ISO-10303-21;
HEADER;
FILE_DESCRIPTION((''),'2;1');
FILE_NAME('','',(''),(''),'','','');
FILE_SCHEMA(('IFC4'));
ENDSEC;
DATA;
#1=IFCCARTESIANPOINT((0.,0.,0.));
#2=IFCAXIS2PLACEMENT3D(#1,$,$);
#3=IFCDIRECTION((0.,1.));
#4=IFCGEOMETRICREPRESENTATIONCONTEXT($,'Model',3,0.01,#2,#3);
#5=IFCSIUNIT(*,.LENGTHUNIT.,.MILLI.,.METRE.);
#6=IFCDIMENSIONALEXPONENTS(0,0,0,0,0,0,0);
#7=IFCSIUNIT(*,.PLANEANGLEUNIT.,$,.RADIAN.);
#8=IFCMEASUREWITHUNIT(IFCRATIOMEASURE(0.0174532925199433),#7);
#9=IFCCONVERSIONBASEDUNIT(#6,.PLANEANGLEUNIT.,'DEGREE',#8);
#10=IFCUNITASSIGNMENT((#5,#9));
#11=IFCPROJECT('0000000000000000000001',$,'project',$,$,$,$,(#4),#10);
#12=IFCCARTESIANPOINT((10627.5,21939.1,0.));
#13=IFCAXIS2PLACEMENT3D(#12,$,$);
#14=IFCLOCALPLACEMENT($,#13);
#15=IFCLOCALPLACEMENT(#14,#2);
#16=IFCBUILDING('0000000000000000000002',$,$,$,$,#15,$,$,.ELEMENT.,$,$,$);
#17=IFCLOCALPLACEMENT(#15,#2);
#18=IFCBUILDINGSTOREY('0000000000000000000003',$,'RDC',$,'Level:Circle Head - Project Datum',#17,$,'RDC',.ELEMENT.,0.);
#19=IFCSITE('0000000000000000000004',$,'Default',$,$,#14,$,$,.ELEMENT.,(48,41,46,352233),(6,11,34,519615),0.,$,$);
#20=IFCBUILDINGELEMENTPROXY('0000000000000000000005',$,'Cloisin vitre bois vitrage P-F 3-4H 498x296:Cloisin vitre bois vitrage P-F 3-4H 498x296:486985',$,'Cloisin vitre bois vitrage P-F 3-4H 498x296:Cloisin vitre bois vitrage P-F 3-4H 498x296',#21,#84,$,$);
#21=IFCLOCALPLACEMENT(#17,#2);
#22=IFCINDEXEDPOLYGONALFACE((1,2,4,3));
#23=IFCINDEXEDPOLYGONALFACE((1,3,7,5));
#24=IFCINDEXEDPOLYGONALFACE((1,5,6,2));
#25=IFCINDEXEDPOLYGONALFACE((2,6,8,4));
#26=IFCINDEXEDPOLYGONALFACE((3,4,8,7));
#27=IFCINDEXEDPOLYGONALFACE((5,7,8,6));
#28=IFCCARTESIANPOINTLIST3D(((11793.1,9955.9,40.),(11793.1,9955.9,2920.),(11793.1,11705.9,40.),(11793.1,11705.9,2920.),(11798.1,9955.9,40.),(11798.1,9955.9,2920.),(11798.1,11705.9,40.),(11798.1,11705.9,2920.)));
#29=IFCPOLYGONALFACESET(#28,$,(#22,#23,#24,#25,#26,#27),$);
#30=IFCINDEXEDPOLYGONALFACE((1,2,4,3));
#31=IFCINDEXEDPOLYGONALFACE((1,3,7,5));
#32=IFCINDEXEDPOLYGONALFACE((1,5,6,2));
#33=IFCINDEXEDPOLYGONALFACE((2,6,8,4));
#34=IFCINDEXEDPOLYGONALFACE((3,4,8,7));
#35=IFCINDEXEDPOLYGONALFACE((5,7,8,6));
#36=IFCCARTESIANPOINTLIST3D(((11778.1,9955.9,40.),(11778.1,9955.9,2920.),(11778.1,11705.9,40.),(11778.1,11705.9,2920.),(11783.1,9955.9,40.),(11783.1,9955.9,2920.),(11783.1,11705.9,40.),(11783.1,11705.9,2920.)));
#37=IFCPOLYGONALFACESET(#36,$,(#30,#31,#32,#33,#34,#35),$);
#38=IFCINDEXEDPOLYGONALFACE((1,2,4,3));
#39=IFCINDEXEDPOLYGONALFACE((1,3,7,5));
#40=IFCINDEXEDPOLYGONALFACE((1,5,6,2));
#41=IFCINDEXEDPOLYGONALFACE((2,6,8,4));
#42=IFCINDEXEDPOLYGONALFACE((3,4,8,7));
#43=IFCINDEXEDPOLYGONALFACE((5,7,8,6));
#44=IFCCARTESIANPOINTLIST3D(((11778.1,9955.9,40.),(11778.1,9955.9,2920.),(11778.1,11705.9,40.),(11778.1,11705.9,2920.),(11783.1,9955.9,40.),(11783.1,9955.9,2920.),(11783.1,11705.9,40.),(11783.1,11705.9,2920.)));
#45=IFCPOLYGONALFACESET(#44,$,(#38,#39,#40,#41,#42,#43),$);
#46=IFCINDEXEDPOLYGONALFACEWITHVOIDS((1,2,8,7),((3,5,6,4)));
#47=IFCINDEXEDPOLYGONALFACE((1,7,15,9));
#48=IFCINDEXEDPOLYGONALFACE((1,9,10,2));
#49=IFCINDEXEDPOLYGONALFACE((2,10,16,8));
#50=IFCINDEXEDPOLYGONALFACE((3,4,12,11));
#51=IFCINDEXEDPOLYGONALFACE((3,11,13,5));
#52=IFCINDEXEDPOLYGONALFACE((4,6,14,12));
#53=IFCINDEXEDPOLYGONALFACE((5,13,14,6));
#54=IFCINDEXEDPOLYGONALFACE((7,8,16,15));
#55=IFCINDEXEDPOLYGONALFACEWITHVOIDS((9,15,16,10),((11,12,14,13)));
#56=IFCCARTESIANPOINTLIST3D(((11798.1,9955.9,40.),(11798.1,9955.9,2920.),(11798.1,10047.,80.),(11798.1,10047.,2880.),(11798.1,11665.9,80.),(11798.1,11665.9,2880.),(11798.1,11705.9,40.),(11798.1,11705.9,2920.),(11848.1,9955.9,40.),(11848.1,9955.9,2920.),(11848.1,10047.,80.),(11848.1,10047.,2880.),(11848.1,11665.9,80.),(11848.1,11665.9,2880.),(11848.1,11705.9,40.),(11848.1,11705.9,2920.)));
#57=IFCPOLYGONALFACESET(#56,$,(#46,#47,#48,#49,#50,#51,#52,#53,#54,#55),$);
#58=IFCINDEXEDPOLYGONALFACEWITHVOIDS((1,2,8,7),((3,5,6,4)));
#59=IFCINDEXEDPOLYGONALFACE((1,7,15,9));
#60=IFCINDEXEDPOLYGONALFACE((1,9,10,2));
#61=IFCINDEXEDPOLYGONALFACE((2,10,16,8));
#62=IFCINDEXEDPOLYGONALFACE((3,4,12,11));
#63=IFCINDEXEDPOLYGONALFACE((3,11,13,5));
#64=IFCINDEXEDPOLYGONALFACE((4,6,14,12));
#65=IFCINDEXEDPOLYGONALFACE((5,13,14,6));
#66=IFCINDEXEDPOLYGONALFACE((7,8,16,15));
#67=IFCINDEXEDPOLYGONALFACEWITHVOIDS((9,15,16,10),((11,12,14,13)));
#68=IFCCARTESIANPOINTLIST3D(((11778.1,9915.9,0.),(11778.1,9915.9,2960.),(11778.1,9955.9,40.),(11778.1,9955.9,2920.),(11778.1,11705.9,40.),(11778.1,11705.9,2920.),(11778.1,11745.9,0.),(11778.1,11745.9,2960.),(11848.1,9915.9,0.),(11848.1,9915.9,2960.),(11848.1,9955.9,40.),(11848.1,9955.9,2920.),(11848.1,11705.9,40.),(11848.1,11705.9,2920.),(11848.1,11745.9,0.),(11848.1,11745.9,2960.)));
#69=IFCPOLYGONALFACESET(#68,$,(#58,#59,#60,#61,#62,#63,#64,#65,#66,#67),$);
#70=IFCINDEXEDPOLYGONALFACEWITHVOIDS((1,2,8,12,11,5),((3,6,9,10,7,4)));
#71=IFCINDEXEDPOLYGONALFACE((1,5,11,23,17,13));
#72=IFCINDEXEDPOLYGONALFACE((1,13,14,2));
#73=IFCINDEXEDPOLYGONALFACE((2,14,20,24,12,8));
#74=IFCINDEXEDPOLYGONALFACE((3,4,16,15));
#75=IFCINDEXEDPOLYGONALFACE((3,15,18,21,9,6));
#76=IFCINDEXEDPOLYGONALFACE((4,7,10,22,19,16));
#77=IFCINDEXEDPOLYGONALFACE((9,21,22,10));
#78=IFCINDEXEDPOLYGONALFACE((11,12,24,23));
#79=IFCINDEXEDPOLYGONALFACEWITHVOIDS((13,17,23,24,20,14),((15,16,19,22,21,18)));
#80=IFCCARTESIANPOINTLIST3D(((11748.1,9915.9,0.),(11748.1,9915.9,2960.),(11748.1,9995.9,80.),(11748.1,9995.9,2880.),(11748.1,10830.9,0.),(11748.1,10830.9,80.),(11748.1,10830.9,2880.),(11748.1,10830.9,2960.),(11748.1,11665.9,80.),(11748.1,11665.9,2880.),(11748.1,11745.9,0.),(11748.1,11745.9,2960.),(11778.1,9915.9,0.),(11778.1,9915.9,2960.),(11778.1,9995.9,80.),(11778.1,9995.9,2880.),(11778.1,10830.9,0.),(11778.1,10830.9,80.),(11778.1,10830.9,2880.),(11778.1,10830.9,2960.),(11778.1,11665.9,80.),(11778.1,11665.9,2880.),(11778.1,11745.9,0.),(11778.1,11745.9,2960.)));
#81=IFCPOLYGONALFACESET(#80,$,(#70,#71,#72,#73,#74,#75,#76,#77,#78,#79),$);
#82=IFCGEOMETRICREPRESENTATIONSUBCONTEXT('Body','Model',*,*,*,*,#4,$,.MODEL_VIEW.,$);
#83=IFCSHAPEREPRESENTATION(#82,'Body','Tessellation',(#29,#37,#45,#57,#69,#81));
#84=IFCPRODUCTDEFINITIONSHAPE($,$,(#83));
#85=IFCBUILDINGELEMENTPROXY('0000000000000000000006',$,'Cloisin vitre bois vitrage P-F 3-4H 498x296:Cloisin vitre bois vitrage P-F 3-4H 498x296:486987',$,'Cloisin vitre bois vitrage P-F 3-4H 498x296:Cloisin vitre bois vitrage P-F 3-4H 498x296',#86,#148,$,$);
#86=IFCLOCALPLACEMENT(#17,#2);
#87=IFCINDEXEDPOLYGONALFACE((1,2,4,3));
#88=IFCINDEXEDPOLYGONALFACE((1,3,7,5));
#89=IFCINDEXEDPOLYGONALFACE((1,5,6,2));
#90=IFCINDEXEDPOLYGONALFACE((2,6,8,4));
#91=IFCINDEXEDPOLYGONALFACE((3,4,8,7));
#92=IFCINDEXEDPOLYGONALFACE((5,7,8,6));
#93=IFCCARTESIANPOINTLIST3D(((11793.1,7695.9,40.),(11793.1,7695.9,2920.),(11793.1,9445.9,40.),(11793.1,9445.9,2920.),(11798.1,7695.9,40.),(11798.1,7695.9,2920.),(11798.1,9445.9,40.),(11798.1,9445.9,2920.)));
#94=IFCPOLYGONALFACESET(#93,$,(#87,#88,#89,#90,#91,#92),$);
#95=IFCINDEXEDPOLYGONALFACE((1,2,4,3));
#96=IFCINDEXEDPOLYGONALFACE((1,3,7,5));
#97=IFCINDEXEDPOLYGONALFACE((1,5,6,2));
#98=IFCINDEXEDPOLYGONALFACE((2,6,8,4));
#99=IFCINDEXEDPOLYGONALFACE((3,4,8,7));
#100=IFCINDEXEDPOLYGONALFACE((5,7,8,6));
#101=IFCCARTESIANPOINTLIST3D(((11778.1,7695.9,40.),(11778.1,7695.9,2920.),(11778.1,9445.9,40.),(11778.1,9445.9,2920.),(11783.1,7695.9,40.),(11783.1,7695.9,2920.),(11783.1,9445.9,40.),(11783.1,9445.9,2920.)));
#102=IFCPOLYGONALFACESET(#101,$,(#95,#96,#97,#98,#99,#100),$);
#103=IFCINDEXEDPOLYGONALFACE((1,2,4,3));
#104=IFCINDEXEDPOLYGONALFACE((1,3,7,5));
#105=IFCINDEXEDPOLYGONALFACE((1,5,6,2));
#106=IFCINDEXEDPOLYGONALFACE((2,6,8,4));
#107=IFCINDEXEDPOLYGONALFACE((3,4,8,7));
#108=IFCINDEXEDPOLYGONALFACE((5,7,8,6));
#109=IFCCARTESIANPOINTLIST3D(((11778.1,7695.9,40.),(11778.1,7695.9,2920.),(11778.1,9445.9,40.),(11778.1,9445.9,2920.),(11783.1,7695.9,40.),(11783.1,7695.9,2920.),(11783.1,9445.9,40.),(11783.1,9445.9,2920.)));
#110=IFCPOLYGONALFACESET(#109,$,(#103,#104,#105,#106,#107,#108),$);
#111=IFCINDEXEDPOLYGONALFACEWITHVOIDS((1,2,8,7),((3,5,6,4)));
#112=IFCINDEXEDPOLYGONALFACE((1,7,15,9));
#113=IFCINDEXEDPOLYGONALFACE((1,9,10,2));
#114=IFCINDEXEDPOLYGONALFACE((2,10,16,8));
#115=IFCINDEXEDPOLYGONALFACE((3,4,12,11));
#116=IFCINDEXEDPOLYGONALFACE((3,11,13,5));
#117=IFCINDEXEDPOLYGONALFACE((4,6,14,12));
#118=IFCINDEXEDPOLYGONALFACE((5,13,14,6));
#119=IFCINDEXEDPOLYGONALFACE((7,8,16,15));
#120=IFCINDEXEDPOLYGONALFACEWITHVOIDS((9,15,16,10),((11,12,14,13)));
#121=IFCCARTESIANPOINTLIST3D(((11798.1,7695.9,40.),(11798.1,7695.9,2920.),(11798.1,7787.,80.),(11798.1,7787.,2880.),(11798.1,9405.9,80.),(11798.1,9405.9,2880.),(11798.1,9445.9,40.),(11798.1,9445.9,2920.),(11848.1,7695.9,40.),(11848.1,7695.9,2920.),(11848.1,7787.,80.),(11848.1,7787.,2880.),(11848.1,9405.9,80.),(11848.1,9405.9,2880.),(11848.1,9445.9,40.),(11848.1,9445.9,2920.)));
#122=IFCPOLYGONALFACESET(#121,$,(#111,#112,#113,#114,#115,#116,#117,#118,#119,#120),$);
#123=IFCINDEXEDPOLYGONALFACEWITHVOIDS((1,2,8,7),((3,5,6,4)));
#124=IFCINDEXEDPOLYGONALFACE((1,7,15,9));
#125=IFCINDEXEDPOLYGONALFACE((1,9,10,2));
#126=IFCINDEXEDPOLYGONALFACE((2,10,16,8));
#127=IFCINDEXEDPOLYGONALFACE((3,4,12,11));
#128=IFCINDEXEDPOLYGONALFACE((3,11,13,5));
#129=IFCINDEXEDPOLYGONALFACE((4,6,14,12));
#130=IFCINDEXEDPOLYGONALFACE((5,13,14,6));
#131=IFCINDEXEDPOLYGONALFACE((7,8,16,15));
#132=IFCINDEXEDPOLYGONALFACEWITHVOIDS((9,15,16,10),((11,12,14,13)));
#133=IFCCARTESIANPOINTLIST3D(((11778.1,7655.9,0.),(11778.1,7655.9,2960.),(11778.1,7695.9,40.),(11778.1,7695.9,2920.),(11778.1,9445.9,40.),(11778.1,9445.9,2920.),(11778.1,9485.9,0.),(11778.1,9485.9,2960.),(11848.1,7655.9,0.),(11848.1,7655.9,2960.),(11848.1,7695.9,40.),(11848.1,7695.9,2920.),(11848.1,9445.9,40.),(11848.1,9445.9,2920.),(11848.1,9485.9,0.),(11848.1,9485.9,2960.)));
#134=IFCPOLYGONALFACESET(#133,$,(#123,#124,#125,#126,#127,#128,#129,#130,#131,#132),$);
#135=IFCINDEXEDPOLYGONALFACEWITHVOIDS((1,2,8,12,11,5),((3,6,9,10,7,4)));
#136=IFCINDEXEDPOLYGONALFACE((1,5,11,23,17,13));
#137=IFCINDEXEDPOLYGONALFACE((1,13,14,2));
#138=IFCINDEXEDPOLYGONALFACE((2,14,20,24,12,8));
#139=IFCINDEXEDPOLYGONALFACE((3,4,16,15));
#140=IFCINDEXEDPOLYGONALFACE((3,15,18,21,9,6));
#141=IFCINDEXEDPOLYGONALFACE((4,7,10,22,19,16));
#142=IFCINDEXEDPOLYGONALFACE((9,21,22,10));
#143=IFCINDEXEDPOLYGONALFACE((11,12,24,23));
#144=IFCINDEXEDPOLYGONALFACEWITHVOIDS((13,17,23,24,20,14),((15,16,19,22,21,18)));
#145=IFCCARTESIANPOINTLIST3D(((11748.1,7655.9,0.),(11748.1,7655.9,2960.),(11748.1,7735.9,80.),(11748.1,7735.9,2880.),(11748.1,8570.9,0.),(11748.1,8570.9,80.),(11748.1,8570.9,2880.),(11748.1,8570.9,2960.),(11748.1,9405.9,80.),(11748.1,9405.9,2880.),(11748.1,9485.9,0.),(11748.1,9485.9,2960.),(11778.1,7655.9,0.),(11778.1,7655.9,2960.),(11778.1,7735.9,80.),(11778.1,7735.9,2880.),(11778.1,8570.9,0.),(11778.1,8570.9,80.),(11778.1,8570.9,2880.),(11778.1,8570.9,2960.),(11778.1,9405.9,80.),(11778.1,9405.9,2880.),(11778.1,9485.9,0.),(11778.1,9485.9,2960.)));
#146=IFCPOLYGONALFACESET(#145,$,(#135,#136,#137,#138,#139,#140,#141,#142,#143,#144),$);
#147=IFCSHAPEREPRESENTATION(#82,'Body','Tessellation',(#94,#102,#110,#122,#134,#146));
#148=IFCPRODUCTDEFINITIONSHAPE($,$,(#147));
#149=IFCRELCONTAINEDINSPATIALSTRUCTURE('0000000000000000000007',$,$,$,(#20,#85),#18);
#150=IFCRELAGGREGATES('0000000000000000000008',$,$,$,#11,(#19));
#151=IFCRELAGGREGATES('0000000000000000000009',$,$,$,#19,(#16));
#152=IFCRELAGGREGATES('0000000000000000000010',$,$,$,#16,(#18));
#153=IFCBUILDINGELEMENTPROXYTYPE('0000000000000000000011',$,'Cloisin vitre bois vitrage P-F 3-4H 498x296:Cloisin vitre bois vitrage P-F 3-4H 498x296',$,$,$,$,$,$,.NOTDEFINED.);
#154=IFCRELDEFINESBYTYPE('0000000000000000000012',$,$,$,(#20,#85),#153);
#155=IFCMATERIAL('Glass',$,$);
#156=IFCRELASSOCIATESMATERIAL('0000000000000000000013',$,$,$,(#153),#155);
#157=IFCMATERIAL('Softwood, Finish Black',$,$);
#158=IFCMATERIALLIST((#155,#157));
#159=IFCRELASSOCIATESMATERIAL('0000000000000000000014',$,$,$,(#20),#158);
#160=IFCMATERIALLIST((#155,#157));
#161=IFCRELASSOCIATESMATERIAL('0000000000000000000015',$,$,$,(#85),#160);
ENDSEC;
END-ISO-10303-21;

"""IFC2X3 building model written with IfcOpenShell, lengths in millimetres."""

from ifc_helpers import new_model, entity, si_unit, converted_unit, direction, frame, frame_2d, origin, place, context, subcontext, project, spatial, polyline, rectangle, outline, extrude, source, transform, mapped, material, material_list, type_object, type_shapes, element, save


model = new_model("IFC2X3")

# Units and contexts
model_context = context("Model", 3, precision=0.01, world=origin(), true_north=direction((0.0, 1.0)))
body_context = subcontext(model_context, "Body", "Model", "MODEL_VIEW")
ifc_project = project(units=[si_unit("LENGTHUNIT", "METRE", prefix="MILLI"), converted_unit("PLANEANGLEUNIT", "DEGREE", entity("IfcRatioMeasure", 0.0174532925199433), si_unit("PLANEANGLEUNIT", "RADIAN"), dimensions=[0, 0, 0, 0, 0, 0, 0])], contexts=[model_context])

# Site, building, storey
site_placement = place(None, frame((10627.5, 21939.1, 0.0)))
site = spatial("IfcSite", under=ifc_project, at=site_placement, Name="Default", CompositionType="ELEMENT", RefLatitude=(48, 41, 46, 352233), RefLongitude=(6, 11, 34, 519615), RefElevation=0.0)
building_placement = place(site_placement, origin())
building = spatial("IfcBuilding", under=site, at=building_placement, CompositionType="ELEMENT")
storey_placement = place(building_placement, origin())
storey = spatial("IfcBuildingStorey", under=building, at=storey_placement, Name="RDC", ObjectType="Level:Circle Head - Project Datum", LongName="RDC", CompositionType="ELEMENT", Elevation=0.0)

# Shared definitions
ifc_material_1 = material(Name="Glass")

# Building element proxies
ifc_material_2 = material(Name="Softwood, Finish Black")
building_element_proxy_type = type_object("IfcBuildingElementProxyType", Name="Cloisin vitre bois vitrage P-F 3-4H 498x296:Cloisin vitre bois vitrage P-F 3-4H 498x296", PredefinedType="NOTDEFINED", material=ifc_material_1)
shared_shape_1 = source(origin(), body_context, "Body", "SweptSolid", [
    extrude(rectangle(XDim=1750.0, YDim=5.0, at=frame_2d((0.0, 0.0), x_axis=(1.0, 0.0))), frame((0.0, 47.5, 40.0), z_axis=(0.0, 0.0, 1.0), x_axis=(-1.0, 0.0, 0.0)), (0.0, 0.0, 1.0), 2880.0),
    extrude(rectangle(XDim=1750.0, YDim=5.0, at=frame_2d((0.0, 0.0), x_axis=(1.0, 0.0))), frame((0.0, 32.5, 40.0), z_axis=(0.0, 0.0, 1.0), x_axis=(-1.0, 0.0, 0.0)), (0.0, 0.0, 1.0), 2880.0),
    extrude(rectangle(XDim=1750.0, YDim=5.0, at=frame_2d((0.0, 0.0), x_axis=(1.0, 0.0))), frame((0.0, 32.5, 40.0), z_axis=(0.0, 0.0, 1.0), x_axis=(-1.0, 0.0, 0.0)), (0.0, 0.0, 1.0), 2880.0),
    extrude(outline(polyline([(-1440.0, -875.0), (1440.0, -875.0), (1440.0, 875.0), (-1440.0, 875.0), (-1440.0, -875.0)]), holes=[polyline([(1400.0, 835.0), (1400.0, -783.9), (-1400.0, -783.9), (-1400.0, 835.0), (1400.0, 835.0)])]), frame((0.0, 50.0, 1480.0), z_axis=(0.0, 1.0, 0.0), x_axis=(0.0, 0.0, -1.0)), (0.0, 0.0, 1.0), 50.0),
    extrude(outline(polyline([(-1480.0, -915.0), (1480.0, -915.0), (1480.0, 915.0), (-1480.0, 915.0), (-1480.0, -915.0)]), holes=[polyline([(-1440.0, -875.0), (-1440.0, 875.0), (1440.0, 875.0), (1440.0, -875.0), (-1440.0, -875.0)])]), frame((0.0, 30.0, 1480.0), z_axis=(0.0, 1.0, 0.0), x_axis=(0.0, 0.0, -1.0)), (0.0, 0.0, 1.0), 70.0),
    extrude(outline(polyline([(-1480.0, -915.0), (1480.0, -915.0), (1480.0, 0.0), (1480.0, 915.0), (-1480.0, 915.0), (-1480.0, 0.0), (-1480.0, -915.0)]), holes=[polyline([(1400.0, 0.0), (1400.0, -835.0), (-1400.0, -835.0), (-1400.0, 0.0), (-1400.0, 835.0), (1400.0, 835.0), (1400.0, 0.0)])]), frame((0.0, 0.0, 1480.0), z_axis=(0.0, 1.0, 0.0), x_axis=(0.0, 0.0, 1.0)), (0.0, 0.0, 1.0), 30.0),
])
type_shapes(building_element_proxy_type, [shared_shape_1])
ifc_material_list_1 = material_list([ifc_material_1, ifc_material_2])
proxy_1_placement = place(storey_placement, frame((11748.1, 10830.9, 0.0), z_axis=(0.0, 0.0, 1.0), x_axis=(0.0, -1.0, 0.0)))
element("IfcBuildingElementProxy", 1, at=proxy_1_placement, inside=storey, type_object=building_element_proxy_type, material=ifc_material_list_1, Name="Cloisin vitre bois vitrage P-F 3-4H 498x296:Cloisin vitre bois vitrage P-F 3-4H 498x296:486985", ObjectType="Cloisin vitre bois vitrage P-F 3-4H 498x296:Cloisin vitre bois vitrage P-F 3-4H 498x296", context=body_context, shape_type="MappedRepresentation", body=[
    mapped(shared_shape_1, transform((0.0, 0.0, 0.0), scale=1.0)),
])
ifc_material_list_2 = material_list([ifc_material_1, ifc_material_2])
proxy_2_placement = place(storey_placement, frame((11748.1, 8570.9, 0.0), z_axis=(0.0, 0.0, 1.0), x_axis=(0.0, -1.0, 0.0)))
element("IfcBuildingElementProxy", 2, at=proxy_2_placement, inside=storey, type_object=building_element_proxy_type, material=ifc_material_list_2, Name="Cloisin vitre bois vitrage P-F 3-4H 498x296:Cloisin vitre bois vitrage P-F 3-4H 498x296:486987", ObjectType="Cloisin vitre bois vitrage P-F 3-4H 498x296:Cloisin vitre bois vitrage P-F 3-4H 498x296", context=body_context, shape_type="MappedRepresentation", body=[
    mapped(shared_shape_1, transform((0.0, 0.0, 0.0), scale=1.0)),
])

save(model, "model.ifc")
